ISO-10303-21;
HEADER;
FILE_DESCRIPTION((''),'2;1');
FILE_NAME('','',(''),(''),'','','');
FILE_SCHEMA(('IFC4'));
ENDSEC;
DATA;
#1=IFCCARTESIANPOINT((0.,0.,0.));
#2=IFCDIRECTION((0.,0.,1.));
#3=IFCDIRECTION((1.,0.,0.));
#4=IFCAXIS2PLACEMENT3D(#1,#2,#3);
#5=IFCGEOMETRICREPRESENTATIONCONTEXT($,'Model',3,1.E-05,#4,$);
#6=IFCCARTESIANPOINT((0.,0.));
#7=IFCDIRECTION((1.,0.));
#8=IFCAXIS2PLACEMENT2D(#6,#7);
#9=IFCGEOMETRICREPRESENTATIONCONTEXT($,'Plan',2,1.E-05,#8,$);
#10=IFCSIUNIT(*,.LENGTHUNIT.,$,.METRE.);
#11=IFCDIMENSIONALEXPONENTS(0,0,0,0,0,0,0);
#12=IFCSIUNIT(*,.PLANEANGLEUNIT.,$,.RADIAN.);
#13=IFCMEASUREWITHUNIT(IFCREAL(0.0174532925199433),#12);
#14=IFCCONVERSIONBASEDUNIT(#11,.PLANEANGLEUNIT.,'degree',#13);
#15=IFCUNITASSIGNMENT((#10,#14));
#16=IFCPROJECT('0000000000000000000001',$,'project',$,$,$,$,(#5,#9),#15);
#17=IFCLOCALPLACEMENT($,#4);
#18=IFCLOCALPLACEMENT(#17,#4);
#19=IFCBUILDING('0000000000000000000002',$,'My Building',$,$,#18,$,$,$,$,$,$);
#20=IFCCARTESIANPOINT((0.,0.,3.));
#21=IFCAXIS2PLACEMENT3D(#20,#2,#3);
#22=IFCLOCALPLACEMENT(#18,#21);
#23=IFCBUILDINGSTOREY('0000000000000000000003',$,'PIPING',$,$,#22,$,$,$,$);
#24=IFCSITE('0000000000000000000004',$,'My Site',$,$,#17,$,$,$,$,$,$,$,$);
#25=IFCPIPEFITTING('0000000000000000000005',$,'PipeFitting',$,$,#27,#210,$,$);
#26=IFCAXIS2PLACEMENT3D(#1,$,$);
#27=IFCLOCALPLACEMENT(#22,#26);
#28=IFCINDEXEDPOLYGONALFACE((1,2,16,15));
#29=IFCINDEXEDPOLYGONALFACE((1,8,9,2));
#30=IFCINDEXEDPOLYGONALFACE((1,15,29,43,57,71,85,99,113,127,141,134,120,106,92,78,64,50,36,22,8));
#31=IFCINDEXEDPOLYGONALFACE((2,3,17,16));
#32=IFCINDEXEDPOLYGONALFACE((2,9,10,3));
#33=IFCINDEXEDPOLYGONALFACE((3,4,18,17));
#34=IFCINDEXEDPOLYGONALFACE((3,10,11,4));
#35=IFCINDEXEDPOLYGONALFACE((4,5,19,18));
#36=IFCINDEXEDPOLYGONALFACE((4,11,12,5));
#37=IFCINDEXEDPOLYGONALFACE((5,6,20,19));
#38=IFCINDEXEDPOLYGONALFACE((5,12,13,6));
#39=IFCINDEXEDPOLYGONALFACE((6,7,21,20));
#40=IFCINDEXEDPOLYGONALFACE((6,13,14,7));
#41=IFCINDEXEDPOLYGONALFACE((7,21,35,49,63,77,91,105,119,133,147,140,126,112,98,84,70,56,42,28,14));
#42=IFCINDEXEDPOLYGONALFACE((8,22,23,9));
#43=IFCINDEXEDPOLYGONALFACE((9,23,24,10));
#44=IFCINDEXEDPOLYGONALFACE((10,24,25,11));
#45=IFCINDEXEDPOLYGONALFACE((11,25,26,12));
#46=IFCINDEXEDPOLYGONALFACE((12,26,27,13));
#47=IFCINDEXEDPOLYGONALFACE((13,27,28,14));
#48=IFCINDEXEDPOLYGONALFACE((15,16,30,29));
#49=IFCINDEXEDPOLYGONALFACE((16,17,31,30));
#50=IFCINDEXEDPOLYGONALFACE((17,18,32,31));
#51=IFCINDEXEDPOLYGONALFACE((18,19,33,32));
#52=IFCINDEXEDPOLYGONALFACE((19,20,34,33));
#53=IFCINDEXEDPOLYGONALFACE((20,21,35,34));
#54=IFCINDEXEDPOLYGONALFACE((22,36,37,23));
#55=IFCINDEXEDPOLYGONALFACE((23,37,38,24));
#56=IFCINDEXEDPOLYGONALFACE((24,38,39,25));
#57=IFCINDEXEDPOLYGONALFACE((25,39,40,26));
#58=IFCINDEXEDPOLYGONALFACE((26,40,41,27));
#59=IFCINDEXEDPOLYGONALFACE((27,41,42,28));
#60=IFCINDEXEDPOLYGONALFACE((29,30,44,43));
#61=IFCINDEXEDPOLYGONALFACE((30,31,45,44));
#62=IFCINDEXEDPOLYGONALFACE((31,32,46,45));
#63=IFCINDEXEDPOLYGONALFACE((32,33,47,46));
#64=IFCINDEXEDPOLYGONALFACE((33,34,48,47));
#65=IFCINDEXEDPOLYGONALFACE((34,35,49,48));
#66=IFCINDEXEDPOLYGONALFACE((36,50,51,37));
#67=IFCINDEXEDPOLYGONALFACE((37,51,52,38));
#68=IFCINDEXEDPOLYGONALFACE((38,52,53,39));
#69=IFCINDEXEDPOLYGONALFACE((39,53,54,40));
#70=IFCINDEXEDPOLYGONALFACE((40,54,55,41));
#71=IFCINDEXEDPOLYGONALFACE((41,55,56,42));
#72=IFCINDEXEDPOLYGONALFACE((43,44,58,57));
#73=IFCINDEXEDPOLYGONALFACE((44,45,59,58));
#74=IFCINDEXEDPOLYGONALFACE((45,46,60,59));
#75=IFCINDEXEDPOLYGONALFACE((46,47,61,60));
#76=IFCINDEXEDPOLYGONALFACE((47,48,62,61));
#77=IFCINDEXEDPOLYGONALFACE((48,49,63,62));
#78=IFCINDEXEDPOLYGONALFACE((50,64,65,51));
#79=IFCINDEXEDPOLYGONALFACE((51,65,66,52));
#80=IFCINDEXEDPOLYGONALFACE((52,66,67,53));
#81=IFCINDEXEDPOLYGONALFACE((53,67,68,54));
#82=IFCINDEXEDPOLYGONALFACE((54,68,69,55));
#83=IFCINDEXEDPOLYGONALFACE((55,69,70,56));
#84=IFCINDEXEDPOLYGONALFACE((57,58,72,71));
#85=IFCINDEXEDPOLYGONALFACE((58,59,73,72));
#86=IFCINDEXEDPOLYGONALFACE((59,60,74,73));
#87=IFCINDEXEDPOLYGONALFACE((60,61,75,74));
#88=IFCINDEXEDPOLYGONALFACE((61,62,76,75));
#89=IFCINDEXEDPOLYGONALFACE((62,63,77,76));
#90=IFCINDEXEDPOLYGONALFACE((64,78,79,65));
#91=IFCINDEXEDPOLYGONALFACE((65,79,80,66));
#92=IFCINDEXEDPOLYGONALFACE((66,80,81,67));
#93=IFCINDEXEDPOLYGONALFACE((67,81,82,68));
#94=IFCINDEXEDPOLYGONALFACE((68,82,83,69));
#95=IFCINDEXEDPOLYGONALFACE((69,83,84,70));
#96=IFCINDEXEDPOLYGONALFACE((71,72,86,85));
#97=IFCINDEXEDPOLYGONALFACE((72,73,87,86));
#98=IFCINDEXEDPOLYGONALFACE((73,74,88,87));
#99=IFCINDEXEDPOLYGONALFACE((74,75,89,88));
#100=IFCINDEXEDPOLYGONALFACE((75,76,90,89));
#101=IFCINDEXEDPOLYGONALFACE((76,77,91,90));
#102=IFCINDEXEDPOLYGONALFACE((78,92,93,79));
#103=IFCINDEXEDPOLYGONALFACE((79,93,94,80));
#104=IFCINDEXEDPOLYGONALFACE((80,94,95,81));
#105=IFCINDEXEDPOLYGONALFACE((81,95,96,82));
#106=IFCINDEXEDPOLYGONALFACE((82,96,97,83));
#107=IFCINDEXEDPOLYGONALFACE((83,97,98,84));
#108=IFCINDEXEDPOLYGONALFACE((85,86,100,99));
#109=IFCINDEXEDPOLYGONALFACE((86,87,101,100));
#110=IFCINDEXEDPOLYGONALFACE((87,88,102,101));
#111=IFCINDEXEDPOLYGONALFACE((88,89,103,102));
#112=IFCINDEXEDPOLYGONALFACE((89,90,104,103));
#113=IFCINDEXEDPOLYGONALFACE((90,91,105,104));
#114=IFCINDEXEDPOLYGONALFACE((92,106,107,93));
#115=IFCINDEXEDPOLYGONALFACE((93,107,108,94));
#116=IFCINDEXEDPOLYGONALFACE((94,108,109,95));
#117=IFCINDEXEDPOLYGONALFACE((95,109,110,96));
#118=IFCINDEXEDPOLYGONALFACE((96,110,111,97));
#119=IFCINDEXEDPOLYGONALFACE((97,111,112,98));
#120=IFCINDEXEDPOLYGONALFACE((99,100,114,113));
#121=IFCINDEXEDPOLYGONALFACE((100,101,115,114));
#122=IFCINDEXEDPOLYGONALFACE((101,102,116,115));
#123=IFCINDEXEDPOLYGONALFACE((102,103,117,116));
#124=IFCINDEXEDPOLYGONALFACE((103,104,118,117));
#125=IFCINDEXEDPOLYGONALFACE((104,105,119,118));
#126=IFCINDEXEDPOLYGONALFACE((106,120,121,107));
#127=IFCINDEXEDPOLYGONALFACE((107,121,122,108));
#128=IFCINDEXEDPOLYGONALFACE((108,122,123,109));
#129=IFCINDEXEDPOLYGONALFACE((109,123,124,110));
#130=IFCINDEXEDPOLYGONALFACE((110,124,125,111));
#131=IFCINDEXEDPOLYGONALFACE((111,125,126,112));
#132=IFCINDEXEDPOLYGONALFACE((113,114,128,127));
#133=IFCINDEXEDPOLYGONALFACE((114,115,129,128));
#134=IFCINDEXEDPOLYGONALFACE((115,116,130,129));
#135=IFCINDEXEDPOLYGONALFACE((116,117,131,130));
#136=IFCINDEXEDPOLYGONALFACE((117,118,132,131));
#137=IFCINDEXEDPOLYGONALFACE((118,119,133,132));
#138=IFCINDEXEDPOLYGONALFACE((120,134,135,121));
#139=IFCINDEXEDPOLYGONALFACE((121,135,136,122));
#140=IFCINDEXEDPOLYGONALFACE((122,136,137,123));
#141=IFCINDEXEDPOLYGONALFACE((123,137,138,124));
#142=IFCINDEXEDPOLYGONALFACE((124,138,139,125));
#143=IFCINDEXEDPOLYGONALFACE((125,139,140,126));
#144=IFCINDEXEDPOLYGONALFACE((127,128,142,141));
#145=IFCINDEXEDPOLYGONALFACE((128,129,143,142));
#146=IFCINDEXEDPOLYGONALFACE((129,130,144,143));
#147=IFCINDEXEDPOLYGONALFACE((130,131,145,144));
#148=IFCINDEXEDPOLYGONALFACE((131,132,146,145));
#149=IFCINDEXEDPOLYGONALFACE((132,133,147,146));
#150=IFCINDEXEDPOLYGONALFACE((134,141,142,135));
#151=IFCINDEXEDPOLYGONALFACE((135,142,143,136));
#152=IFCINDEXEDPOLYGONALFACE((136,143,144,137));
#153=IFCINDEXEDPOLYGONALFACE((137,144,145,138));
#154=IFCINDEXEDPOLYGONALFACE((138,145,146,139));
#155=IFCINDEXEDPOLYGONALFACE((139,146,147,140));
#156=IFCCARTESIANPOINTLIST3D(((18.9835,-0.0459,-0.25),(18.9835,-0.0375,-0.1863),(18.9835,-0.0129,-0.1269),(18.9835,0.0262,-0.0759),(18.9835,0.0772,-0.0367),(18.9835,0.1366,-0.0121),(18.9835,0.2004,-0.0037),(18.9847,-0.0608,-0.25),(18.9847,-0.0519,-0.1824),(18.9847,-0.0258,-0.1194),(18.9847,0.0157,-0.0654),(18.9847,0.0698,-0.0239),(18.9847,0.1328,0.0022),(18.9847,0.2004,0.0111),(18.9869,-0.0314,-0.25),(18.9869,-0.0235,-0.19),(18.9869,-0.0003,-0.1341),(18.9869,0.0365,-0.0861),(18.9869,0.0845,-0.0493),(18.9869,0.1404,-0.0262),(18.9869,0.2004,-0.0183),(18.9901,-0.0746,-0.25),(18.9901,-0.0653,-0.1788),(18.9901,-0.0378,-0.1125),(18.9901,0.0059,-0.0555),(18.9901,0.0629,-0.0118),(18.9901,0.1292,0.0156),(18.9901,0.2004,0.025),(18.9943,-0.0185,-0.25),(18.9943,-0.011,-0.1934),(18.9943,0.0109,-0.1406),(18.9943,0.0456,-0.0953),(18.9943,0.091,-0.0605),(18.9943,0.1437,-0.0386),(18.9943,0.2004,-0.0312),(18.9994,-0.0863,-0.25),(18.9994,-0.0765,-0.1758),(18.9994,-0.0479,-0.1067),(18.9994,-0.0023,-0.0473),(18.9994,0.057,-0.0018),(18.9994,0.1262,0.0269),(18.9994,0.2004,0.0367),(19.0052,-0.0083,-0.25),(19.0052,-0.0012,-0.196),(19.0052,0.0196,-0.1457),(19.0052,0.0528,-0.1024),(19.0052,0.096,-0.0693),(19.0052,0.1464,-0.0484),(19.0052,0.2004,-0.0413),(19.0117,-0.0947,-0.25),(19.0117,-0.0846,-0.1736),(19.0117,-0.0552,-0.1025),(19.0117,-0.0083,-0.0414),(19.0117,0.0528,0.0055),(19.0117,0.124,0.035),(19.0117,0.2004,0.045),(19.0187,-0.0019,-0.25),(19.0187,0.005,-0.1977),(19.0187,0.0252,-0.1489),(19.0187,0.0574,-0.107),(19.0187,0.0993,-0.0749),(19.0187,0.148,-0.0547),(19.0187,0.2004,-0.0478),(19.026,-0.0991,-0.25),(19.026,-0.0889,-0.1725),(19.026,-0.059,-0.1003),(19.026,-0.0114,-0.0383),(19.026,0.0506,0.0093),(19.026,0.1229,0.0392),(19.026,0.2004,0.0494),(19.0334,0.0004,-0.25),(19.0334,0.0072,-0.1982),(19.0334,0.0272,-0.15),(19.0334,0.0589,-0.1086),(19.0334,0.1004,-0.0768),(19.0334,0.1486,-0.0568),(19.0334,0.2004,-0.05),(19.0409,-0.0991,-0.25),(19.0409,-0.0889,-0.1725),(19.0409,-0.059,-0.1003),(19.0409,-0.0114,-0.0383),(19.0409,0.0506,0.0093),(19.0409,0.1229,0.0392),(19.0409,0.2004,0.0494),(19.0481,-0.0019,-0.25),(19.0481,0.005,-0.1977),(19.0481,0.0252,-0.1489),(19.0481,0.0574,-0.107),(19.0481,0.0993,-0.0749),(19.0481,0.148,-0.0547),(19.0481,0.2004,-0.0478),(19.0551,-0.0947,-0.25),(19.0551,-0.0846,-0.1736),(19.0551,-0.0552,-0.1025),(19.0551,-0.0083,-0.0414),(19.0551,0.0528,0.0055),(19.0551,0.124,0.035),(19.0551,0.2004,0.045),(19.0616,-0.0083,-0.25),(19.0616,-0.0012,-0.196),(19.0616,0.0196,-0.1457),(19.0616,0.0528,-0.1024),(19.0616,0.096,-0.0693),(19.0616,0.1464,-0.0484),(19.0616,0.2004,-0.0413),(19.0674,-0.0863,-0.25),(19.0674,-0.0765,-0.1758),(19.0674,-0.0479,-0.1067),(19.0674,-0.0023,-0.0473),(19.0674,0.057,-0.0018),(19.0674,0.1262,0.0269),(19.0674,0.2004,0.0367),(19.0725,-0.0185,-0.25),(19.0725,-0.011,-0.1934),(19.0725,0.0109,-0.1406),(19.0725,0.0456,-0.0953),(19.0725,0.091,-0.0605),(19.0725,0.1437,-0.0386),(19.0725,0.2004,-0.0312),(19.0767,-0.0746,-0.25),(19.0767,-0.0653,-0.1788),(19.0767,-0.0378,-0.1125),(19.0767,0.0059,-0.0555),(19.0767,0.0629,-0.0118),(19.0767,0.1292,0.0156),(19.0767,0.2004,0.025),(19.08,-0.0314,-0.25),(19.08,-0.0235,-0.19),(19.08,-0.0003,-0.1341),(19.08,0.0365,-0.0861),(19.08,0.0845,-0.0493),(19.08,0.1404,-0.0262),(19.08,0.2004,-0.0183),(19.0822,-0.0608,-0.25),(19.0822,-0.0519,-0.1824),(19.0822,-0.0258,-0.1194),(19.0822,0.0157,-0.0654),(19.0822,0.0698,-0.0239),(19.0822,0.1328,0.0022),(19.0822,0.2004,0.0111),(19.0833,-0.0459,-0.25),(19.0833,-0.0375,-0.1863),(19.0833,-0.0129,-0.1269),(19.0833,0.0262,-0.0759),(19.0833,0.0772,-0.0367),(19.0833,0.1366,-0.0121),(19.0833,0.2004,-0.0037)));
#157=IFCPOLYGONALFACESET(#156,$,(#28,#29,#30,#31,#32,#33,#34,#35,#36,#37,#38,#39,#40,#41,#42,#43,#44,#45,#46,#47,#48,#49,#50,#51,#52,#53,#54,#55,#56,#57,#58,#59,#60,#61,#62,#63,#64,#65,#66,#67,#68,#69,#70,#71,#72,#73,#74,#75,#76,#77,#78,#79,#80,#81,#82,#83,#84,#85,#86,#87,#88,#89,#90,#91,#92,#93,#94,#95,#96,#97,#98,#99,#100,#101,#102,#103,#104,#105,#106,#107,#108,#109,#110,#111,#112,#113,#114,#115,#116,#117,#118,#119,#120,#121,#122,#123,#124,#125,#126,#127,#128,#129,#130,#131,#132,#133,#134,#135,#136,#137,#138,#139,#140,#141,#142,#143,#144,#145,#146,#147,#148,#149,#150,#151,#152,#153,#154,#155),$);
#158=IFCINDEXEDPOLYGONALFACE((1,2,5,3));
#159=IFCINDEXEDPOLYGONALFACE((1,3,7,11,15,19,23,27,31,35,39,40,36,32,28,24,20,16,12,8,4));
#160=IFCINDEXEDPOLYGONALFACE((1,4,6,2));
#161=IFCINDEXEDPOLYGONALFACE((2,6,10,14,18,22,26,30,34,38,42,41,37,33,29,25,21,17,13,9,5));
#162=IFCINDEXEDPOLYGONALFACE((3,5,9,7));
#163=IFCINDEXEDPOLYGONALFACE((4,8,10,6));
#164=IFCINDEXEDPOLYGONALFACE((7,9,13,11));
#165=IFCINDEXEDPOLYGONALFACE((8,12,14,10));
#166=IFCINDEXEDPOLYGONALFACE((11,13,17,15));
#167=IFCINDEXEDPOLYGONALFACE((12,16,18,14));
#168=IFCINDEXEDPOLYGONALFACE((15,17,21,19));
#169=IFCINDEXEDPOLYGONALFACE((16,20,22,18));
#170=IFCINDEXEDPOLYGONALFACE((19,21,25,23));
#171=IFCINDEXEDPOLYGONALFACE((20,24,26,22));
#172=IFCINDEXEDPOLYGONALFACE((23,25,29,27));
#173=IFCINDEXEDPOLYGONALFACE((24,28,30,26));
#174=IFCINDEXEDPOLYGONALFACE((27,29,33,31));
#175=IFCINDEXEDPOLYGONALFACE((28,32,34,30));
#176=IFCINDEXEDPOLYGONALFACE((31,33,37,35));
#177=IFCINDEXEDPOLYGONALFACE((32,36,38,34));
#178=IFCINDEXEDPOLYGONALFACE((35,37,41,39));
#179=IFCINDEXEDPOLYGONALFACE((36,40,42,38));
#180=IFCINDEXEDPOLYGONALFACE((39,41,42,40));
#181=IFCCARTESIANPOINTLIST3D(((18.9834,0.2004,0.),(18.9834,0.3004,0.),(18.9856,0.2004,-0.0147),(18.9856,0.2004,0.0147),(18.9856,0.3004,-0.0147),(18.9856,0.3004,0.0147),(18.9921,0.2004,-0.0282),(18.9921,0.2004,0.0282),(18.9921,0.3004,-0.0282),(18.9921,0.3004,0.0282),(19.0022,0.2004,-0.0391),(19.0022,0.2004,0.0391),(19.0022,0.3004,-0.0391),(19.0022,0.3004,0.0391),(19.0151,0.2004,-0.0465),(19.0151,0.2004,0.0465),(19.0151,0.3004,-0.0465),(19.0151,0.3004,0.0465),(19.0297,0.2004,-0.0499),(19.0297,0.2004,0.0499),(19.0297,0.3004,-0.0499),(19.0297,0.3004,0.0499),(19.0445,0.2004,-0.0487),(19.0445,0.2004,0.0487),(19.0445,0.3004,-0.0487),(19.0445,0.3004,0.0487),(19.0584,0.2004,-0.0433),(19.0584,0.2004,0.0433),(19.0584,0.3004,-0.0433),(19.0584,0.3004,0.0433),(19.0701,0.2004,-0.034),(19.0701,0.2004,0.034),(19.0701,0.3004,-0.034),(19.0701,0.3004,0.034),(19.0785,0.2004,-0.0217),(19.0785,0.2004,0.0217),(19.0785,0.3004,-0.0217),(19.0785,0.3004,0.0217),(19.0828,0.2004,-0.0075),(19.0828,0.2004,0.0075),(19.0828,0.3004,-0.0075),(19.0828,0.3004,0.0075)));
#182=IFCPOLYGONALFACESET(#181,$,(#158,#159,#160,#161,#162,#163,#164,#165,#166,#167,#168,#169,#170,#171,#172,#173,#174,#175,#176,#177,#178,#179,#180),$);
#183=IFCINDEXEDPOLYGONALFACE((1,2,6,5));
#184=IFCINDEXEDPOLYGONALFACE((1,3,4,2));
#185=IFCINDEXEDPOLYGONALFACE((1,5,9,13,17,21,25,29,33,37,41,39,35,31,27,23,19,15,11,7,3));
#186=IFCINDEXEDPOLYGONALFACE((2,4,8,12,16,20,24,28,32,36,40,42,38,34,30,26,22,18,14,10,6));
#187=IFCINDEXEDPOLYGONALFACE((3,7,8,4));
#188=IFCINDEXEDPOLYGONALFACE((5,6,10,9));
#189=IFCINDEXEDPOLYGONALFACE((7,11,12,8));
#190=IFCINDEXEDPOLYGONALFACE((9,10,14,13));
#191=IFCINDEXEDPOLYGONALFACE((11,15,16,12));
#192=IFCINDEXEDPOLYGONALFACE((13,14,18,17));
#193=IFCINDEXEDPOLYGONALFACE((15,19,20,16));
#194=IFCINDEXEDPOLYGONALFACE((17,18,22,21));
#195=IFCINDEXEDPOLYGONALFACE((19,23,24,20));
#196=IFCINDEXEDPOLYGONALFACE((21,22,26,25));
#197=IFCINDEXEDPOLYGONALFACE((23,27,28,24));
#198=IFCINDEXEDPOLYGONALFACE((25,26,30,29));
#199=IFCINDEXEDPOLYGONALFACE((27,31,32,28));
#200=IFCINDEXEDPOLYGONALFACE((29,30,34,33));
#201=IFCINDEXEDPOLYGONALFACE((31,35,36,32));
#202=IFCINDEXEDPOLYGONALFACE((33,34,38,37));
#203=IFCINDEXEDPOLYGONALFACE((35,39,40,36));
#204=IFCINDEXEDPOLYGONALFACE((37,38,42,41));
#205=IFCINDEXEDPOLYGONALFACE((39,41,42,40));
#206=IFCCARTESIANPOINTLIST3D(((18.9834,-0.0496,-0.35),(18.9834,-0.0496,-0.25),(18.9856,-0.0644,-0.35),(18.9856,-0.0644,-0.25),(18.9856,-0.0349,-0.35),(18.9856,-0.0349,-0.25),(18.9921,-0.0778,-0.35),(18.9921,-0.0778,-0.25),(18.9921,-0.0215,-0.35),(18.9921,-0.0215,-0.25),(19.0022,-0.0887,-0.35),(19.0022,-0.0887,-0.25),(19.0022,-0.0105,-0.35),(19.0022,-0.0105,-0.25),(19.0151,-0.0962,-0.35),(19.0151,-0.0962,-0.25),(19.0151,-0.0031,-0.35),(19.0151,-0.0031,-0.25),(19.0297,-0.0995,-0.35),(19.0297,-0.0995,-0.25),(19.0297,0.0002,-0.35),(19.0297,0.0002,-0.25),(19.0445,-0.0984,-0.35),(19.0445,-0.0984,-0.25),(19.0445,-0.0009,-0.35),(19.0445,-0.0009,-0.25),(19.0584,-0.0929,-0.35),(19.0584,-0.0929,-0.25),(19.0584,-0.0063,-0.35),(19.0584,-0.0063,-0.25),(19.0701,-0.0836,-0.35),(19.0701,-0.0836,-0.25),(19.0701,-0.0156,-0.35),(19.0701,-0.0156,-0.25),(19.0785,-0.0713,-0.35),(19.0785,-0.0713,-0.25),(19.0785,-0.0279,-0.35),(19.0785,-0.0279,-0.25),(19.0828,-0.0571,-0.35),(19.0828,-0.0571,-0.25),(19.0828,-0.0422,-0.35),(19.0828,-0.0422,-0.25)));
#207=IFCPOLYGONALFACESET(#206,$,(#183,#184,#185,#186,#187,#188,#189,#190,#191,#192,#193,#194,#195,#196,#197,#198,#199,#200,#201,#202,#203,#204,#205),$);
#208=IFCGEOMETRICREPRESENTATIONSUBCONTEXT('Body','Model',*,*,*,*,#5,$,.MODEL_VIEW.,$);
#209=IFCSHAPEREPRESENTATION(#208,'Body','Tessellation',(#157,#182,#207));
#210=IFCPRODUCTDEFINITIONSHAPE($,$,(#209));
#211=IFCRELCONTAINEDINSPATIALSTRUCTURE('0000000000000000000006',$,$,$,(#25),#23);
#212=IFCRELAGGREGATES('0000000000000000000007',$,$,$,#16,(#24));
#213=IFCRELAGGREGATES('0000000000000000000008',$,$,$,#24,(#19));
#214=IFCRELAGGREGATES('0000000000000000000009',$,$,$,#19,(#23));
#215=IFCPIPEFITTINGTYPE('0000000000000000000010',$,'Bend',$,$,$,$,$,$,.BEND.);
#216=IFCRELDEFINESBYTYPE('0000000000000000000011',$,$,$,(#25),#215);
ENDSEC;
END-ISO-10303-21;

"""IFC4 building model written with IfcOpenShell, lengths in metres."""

from ifc_helpers import new_model, entity, si_unit, converted_unit, frame, origin_with_axes, origin_2d_with_axis, place, context, subcontext, project, spatial, circle, extrude, source, transform, mapped, type_object, type_shapes, element, save


model = new_model("IFC4")

# Units and contexts
model_context = context("Model", 3, precision=1e-05, world=origin_with_axes())
plan_context = context("Plan", 2, precision=1e-05, world=origin_2d_with_axis())
body_context = subcontext(model_context, "Body", "Model", "MODEL_VIEW")
ifc_project = project(units=[si_unit("LENGTHUNIT", "METRE"), converted_unit("PLANEANGLEUNIT", "degree", entity("IfcReal", 0.0174532925199433), si_unit("PLANEANGLEUNIT", "RADIAN"), dimensions=[0, 0, 0, 0, 0, 0, 0])], contexts=[model_context, plan_context])

# Site, building, storey
site_placement = place(None, origin_with_axes())
site = spatial("IfcSite", under=ifc_project, at=site_placement, Name="My Site")
building_placement = place(site_placement, origin_with_axes())
building = spatial("IfcBuilding", under=site, at=building_placement, Name="My Building")
storey_placement = place(building_placement, frame((0.0, 0.0, 3.0), z_axis=(0.0, 0.0, 1.0), x_axis=(1.0, 0.0, 0.0)))
storey = spatial("IfcBuildingStorey", under=building, at=storey_placement, Name="PIPING")

# Pipe fitting
pipe_fitting_type = type_object("IfcPipeFittingType", Name="Bend", PredefinedType="BEND")
shared_shape = source(origin_with_axes(), body_context, "Body", "SolidModel", [
    entity("IfcSweptDiskSolid", entity("IfcIndexedPolyCurve", entity("IfcCartesianPointList3D", [[0.0, 0.0, -0.1], [0.0, -0.0732, -0.2768], [0.0, -0.25, -0.35]]), [entity("IfcArcIndex", [1, 2, 3])]), 0.05),
    extrude(circle(Radius=0.05), origin_with_axes(), (0.0, 0.0, -1.0), 0.1),
    extrude(circle(Radius=0.05), frame((0.0, -0.25, -0.35), z_axis=(0.0, -1.0, 0.0), x_axis=(1.0, 0.0, 0.0)), (0.0, 0.0, 1.0), 0.1),
])
type_shapes(pipe_fitting_type, [shared_shape])
for number, where, z_axis, x_axis, name in (
    (1, (19.0334, 0.3004, 0.0), (0.0, 1.0, 0.0), (-1.0, 0.0, 0.0), "PipeFitting"),
):
    element("IfcPipeFitting", number, at=place(storey_placement, frame(where, z_axis=z_axis, x_axis=x_axis)), inside=storey, type_object=pipe_fitting_type, Name=name, context=body_context, shape_type="MappedRepresentation", body=[
        mapped(shared_shape, transform((0.0, 0.0, 0.0), x_axis=(1.0, 0.0, 0.0), y_axis=(0.0, 1.0, 0.0), z_axis=(0.0, 0.0, 1.0), scale=1.0)),
    ])

save(model, "model.ifc")
